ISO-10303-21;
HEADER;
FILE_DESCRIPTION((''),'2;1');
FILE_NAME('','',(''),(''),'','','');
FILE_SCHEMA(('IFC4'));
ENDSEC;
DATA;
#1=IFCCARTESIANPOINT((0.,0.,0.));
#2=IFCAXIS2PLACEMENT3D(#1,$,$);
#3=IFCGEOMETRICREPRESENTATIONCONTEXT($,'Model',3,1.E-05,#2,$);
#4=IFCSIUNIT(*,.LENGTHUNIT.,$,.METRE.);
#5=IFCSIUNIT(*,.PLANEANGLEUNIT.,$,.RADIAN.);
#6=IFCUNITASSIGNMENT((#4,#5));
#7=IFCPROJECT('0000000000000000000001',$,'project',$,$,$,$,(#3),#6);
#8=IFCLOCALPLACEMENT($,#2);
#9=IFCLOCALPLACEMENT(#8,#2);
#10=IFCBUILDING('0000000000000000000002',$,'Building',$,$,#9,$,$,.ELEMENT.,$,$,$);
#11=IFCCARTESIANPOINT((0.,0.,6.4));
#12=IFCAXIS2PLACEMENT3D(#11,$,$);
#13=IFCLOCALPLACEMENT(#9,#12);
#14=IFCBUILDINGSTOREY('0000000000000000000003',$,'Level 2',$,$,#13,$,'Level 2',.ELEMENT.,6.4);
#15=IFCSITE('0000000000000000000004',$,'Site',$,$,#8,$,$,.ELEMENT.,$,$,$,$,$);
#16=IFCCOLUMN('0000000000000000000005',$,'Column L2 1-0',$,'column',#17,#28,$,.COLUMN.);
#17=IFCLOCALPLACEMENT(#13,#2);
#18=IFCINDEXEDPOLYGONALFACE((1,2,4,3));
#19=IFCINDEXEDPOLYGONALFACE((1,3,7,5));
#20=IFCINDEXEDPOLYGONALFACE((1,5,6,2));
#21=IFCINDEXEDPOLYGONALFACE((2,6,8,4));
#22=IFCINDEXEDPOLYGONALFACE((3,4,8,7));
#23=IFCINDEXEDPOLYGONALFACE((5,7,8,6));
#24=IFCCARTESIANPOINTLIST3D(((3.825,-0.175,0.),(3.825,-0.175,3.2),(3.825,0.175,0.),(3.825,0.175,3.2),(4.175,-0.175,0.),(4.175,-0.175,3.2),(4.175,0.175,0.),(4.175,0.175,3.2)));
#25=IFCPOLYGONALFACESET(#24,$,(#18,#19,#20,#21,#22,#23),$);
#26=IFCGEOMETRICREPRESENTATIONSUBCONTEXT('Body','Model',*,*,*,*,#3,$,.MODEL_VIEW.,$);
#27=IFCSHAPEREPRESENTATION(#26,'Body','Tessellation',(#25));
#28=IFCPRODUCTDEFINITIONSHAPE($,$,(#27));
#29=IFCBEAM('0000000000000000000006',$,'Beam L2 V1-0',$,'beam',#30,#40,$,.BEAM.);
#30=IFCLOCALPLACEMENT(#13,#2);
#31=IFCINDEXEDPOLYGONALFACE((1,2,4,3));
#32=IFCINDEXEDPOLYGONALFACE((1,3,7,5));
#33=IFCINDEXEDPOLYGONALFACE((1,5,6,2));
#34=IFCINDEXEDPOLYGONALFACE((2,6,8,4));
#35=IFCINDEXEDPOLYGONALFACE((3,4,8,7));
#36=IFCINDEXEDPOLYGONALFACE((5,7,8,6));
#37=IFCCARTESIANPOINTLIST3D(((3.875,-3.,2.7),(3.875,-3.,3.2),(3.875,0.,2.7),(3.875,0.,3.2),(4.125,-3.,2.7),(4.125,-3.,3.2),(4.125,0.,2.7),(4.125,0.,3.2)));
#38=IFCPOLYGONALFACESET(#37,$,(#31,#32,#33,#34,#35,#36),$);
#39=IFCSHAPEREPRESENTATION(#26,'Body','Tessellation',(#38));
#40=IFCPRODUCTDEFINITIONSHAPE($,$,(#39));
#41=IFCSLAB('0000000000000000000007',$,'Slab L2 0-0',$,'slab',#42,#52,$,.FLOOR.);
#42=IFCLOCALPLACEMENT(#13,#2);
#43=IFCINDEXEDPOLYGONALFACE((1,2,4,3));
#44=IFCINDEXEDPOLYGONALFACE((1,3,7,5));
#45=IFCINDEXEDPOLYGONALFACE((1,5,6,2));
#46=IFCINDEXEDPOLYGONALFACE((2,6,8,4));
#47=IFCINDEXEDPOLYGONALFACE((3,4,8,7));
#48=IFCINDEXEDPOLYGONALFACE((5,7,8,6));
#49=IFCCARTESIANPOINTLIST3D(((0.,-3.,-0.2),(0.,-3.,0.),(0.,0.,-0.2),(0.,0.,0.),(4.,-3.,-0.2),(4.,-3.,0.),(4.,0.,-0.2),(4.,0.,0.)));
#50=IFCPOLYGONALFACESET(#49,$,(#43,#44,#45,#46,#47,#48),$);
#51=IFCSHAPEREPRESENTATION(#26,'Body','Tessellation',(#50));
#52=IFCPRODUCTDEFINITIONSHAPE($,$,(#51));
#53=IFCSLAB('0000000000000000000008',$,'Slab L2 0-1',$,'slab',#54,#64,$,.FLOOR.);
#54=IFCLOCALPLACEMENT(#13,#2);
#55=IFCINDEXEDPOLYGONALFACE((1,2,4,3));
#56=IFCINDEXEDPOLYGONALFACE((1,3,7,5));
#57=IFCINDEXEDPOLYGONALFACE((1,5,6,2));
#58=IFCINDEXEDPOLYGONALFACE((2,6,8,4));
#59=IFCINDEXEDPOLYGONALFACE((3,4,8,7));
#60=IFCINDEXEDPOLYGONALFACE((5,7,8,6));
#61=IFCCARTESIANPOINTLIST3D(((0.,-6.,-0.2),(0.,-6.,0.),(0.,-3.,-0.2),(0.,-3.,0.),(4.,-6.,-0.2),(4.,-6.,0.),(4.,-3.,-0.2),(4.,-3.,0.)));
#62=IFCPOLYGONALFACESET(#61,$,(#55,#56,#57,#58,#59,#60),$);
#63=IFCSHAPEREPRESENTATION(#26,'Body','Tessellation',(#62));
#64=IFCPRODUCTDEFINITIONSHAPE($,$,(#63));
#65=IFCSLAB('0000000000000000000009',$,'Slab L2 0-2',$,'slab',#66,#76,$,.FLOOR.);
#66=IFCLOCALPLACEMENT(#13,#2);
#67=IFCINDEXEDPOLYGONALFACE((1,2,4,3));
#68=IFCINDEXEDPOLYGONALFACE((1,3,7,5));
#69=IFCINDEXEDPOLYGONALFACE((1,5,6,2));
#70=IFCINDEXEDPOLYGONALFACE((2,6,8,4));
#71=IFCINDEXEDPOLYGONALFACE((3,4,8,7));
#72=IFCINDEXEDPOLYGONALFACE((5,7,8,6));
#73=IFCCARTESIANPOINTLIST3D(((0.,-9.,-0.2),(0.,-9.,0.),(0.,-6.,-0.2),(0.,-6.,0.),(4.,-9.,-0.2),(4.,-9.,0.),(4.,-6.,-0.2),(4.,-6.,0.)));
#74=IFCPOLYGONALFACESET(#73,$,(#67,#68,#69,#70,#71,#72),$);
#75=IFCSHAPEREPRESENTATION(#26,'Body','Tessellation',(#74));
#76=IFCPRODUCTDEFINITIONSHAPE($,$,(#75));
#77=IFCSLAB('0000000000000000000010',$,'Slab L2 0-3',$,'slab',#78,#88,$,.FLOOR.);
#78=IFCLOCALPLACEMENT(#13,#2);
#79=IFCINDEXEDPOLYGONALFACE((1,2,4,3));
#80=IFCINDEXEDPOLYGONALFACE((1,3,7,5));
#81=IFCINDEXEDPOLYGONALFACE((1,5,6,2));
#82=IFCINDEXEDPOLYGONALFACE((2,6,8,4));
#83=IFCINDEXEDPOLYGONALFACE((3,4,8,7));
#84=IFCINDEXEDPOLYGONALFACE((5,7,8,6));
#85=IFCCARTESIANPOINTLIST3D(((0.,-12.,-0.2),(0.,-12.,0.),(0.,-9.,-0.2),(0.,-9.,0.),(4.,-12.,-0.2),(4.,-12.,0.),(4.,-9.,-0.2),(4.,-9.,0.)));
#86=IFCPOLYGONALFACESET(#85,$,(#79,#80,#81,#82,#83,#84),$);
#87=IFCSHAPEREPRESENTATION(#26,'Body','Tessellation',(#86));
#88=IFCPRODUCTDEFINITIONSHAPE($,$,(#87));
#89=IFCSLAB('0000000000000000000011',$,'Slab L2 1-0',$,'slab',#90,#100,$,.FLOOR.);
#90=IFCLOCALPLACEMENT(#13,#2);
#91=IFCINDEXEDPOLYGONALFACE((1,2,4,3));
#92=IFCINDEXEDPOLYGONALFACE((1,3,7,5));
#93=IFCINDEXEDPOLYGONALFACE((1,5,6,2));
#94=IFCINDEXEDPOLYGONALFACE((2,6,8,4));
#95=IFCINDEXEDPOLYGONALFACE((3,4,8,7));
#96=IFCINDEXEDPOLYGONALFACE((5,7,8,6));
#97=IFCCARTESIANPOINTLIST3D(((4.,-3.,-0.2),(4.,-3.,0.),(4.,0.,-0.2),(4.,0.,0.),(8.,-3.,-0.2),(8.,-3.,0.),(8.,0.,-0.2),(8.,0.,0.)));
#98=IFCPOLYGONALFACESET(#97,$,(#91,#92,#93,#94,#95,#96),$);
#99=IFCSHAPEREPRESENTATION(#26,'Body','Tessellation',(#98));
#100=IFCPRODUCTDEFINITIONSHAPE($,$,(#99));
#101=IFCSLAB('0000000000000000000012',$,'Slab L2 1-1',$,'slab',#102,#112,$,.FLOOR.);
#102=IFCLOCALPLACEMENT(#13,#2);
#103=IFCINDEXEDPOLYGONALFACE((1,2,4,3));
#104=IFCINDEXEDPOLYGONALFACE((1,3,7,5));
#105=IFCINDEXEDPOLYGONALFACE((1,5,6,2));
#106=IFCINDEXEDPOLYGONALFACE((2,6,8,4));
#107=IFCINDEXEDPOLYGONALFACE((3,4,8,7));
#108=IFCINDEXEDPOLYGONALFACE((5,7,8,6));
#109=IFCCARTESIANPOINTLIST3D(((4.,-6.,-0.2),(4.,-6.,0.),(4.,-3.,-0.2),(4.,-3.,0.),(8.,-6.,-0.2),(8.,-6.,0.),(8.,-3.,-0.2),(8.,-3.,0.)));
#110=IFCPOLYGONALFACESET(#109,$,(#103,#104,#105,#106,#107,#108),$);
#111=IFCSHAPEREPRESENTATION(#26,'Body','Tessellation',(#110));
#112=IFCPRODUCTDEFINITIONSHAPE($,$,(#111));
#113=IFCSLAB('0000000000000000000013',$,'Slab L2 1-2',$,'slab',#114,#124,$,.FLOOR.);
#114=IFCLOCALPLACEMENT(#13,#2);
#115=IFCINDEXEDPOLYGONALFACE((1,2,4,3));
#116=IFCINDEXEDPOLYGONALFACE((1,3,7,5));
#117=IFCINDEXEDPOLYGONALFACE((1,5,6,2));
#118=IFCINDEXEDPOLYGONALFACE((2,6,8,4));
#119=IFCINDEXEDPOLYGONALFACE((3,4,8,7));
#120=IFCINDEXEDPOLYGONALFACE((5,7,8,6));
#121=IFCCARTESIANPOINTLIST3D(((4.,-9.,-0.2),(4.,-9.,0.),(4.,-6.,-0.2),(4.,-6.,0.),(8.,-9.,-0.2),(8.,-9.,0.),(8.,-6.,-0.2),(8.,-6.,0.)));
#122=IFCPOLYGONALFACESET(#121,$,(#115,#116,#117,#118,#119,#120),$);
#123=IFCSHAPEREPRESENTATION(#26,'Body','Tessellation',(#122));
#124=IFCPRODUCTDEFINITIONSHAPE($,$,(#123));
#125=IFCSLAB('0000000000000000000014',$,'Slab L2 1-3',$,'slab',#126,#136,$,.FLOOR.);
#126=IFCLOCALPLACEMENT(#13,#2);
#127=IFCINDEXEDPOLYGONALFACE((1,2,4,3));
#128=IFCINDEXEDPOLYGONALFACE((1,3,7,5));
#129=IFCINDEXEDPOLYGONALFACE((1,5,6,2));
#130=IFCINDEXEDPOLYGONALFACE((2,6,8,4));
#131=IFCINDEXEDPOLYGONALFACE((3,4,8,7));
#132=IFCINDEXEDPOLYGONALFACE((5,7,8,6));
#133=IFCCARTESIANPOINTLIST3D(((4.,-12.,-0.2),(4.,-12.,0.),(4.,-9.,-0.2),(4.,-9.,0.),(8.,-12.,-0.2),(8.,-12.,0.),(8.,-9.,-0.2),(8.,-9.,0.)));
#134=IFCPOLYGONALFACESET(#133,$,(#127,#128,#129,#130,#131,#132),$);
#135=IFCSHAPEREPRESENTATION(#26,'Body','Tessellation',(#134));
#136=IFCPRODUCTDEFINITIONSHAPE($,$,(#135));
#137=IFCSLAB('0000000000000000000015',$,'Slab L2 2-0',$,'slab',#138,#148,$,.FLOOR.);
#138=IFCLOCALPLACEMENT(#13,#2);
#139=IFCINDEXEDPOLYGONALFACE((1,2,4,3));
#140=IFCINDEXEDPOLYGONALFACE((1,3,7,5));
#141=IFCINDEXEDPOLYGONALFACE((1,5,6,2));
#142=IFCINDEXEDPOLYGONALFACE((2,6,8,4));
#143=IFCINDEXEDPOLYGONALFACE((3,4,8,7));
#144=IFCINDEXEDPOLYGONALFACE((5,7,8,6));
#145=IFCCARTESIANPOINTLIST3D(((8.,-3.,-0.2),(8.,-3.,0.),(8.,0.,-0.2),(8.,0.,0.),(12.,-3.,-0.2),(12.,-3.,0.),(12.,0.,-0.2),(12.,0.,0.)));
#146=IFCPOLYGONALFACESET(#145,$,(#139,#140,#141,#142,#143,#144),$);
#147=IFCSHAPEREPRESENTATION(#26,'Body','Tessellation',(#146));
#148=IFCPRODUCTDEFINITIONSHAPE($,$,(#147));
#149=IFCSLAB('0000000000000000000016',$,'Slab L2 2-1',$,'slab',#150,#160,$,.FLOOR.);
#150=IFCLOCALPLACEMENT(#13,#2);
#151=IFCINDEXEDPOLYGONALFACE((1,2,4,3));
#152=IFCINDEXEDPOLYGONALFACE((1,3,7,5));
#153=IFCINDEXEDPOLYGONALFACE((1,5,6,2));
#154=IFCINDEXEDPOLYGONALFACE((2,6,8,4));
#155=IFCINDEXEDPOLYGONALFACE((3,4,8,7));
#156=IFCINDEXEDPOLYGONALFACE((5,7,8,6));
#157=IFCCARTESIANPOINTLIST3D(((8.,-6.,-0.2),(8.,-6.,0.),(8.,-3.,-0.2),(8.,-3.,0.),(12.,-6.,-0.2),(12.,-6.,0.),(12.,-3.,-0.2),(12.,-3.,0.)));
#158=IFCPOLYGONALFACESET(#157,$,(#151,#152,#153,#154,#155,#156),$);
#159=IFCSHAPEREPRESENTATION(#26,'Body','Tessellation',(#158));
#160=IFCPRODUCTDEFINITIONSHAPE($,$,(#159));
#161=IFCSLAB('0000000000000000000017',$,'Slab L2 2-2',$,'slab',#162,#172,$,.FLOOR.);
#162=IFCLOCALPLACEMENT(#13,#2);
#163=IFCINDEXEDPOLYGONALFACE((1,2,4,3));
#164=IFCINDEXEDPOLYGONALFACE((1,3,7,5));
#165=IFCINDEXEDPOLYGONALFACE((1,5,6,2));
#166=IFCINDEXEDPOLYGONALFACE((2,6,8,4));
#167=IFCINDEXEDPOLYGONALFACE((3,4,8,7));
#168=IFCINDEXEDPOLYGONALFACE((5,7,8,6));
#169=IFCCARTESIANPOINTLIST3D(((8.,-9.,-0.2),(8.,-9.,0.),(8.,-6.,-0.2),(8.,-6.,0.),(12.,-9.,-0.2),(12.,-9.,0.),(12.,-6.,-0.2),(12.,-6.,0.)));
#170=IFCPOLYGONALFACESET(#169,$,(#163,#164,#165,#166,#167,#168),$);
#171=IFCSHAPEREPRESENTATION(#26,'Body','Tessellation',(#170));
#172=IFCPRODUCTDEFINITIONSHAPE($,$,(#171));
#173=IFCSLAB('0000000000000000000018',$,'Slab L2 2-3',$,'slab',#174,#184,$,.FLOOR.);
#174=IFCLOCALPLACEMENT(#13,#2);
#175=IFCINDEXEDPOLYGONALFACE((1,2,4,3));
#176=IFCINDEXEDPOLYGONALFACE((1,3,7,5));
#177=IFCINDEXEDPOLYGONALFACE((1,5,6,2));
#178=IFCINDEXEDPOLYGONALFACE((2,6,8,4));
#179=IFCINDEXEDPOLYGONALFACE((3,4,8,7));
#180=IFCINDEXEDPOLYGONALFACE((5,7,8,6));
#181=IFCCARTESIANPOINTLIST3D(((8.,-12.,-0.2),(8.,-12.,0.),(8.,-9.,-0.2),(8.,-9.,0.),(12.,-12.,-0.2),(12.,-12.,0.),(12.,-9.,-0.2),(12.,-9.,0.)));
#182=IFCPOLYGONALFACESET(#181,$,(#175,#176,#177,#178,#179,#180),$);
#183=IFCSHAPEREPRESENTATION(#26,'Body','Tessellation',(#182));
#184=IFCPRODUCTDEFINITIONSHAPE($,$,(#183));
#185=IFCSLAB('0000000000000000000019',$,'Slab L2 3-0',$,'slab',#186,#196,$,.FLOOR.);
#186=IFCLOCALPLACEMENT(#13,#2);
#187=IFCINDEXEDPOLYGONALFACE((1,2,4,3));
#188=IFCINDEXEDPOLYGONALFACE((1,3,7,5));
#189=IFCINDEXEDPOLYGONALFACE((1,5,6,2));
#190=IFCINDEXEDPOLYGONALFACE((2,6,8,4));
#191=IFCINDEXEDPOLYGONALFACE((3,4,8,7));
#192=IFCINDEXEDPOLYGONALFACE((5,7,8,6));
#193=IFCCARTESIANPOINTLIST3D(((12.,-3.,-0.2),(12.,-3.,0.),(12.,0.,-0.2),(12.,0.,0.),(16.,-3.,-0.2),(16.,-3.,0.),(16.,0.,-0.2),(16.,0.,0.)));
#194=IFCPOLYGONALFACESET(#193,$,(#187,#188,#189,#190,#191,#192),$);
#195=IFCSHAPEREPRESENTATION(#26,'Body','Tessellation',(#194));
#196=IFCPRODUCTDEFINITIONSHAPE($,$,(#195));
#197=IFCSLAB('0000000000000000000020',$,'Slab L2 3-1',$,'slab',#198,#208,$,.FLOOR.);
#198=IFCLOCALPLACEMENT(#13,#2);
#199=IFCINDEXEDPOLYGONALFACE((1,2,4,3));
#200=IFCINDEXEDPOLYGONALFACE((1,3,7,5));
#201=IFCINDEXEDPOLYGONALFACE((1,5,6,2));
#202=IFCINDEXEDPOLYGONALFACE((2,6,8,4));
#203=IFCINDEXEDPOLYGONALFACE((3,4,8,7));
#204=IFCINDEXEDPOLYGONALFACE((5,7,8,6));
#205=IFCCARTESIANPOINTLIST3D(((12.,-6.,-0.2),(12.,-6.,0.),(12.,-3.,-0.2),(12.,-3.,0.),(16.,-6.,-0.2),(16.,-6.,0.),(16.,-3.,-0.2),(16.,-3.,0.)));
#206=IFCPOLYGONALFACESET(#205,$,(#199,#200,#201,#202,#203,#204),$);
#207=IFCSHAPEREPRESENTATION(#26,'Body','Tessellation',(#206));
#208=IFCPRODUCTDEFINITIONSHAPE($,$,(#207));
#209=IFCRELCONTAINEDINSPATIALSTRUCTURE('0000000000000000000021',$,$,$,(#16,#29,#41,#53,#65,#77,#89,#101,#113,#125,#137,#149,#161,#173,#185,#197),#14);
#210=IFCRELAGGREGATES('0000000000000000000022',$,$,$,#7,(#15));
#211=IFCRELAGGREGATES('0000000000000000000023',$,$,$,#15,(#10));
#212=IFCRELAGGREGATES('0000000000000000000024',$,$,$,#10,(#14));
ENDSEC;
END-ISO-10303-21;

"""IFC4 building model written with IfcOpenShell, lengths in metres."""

from ifc_helpers import new_model, si_unit, frame, origin, origin_2d, place, context, subcontext, project, spatial, polyline, rectangle, outline, extrude, element, save


model = new_model("IFC4")

# Units and contexts
model_context = context("Model", 3, precision=1e-05, world=origin())
body_context = subcontext(model_context, "Body", "Model", "MODEL_VIEW")
ifc_project = project(units=[si_unit("LENGTHUNIT", "METRE"), si_unit("PLANEANGLEUNIT", "RADIAN")], contexts=[model_context])

# Site, building, storey
site_placement = place(None, origin())
site = spatial("IfcSite", under=ifc_project, at=site_placement, Name="Site", CompositionType="ELEMENT")
building_placement = place(site_placement, origin())
building = spatial("IfcBuilding", under=site, at=building_placement, Name="Building", CompositionType="ELEMENT")
storey_placement = place(building_placement, frame((0.0, 0.0, 6.4)))
storey = spatial("IfcBuildingStorey", under=building, at=storey_placement, Name="Level 2", LongName="Level 2", CompositionType="ELEMENT", Elevation=6.4)

# Column
column_placement = place(storey_placement, frame((4.0, 0.0, 0.0)))
element("IfcColumn", 1, at=column_placement, inside=storey, Name="Column L2 1-0", ObjectType="column", PredefinedType="COLUMN", context=body_context, shape_type="SweptSolid", body=[
    extrude(rectangle(XDim=0.35, YDim=0.35, at=origin_2d()), origin(), (0.0, 0.0, 1.0), 3.2),
])

# Beam
beam_placement = place(storey_placement, frame((4.0, 0.0, 2.95), z_axis=(0.0, -1.0, 0.0), x_axis=(0.0, 0.0, 1.0)))
element("IfcBeam", 2, at=beam_placement, inside=storey, Name="Beam L2 V1-0", ObjectType="beam", PredefinedType="BEAM", context=body_context, shape_type="SweptSolid", body=[
    extrude(rectangle(XDim=0.5, YDim=0.25, at=origin_2d()), origin(), (0.0, 0.0, 1.0), 3.0),
])

# Slabs
slab_1_placement = place(storey_placement, frame((0.0, 0.0, -0.2)))
element("IfcSlab", 3, at=slab_1_placement, inside=storey, Name="Slab L2 0-0", ObjectType="slab", PredefinedType="FLOOR", context=body_context, shape_type="SweptSolid", body=[
    extrude(outline(polyline([(0.0, -3.0), (4.0, -3.0), (4.0, 0.0), (0.0, 0.0), (0.0, -3.0)])), origin(), (0.0, 0.0, 1.0), 0.2),
])
slab_2_placement = place(storey_placement, frame((0.0, 0.0, -0.2)))
element("IfcSlab", 4, at=slab_2_placement, inside=storey, Name="Slab L2 0-1", ObjectType="slab", PredefinedType="FLOOR", context=body_context, shape_type="SweptSolid", body=[
    extrude(outline(polyline([(0.0, -6.0), (4.0, -6.0), (4.0, -3.0), (0.0, -3.0), (0.0, -6.0)])), origin(), (0.0, 0.0, 1.0), 0.2),
])
slab_3_placement = place(storey_placement, frame((0.0, 0.0, -0.2)))
element("IfcSlab", 5, at=slab_3_placement, inside=storey, Name="Slab L2 0-2", ObjectType="slab", PredefinedType="FLOOR", context=body_context, shape_type="SweptSolid", body=[
    extrude(outline(polyline([(0.0, -9.0), (4.0, -9.0), (4.0, -6.0), (0.0, -6.0), (0.0, -9.0)])), origin(), (0.0, 0.0, 1.0), 0.2),
])
slab_4_placement = place(storey_placement, frame((0.0, 0.0, -0.2)))
element("IfcSlab", 6, at=slab_4_placement, inside=storey, Name="Slab L2 0-3", ObjectType="slab", PredefinedType="FLOOR", context=body_context, shape_type="SweptSolid", body=[
    extrude(outline(polyline([(0.0, -12.0), (4.0, -12.0), (4.0, -9.0), (0.0, -9.0), (0.0, -12.0)])), origin(), (0.0, 0.0, 1.0), 0.2),
])
slab_5_placement = place(storey_placement, frame((0.0, 0.0, -0.2)))
element("IfcSlab", 7, at=slab_5_placement, inside=storey, Name="Slab L2 1-0", ObjectType="slab", PredefinedType="FLOOR", context=body_context, shape_type="SweptSolid", body=[
    extrude(outline(polyline([(4.0, -3.0), (8.0, -3.0), (8.0, 0.0), (4.0, 0.0), (4.0, -3.0)])), origin(), (0.0, 0.0, 1.0), 0.2),
])
slab_6_placement = place(storey_placement, frame((0.0, 0.0, -0.2)))
element("IfcSlab", 8, at=slab_6_placement, inside=storey, Name="Slab L2 1-1", ObjectType="slab", PredefinedType="FLOOR", context=body_context, shape_type="SweptSolid", body=[
    extrude(outline(polyline([(4.0, -6.0), (8.0, -6.0), (8.0, -3.0), (4.0, -3.0), (4.0, -6.0)])), origin(), (0.0, 0.0, 1.0), 0.2),
])
slab_7_placement = place(storey_placement, frame((0.0, 0.0, -0.2)))
element("IfcSlab", 9, at=slab_7_placement, inside=storey, Name="Slab L2 1-2", ObjectType="slab", PredefinedType="FLOOR", context=body_context, shape_type="SweptSolid", body=[
    extrude(outline(polyline([(4.0, -9.0), (8.0, -9.0), (8.0, -6.0), (4.0, -6.0), (4.0, -9.0)])), origin(), (0.0, 0.0, 1.0), 0.2),
])
slab_8_placement = place(storey_placement, frame((0.0, 0.0, -0.2)))
element("IfcSlab", 10, at=slab_8_placement, inside=storey, Name="Slab L2 1-3", ObjectType="slab", PredefinedType="FLOOR", context=body_context, shape_type="SweptSolid", body=[
    extrude(outline(polyline([(4.0, -12.0), (8.0, -12.0), (8.0, -9.0), (4.0, -9.0), (4.0, -12.0)])), origin(), (0.0, 0.0, 1.0), 0.2),
])
slab_9_placement = place(storey_placement, frame((0.0, 0.0, -0.2)))
element("IfcSlab", 11, at=slab_9_placement, inside=storey, Name="Slab L2 2-0", ObjectType="slab", PredefinedType="FLOOR", context=body_context, shape_type="SweptSolid", body=[
    extrude(outline(polyline([(8.0, -3.0), (12.0, -3.0), (12.0, 0.0), (8.0, 0.0), (8.0, -3.0)])), origin(), (0.0, 0.0, 1.0), 0.2),
])
slab_10_placement = place(storey_placement, frame((0.0, 0.0, -0.2)))
element("IfcSlab", 12, at=slab_10_placement, inside=storey, Name="Slab L2 2-1", ObjectType="slab", PredefinedType="FLOOR", context=body_context, shape_type="SweptSolid", body=[
    extrude(outline(polyline([(8.0, -6.0), (12.0, -6.0), (12.0, -3.0), (8.0, -3.0), (8.0, -6.0)])), origin(), (0.0, 0.0, 1.0), 0.2),
])
slab_11_placement = place(storey_placement, frame((0.0, 0.0, -0.2)))
element("IfcSlab", 13, at=slab_11_placement, inside=storey, Name="Slab L2 2-2", ObjectType="slab", PredefinedType="FLOOR", context=body_context, shape_type="SweptSolid", body=[
    extrude(outline(polyline([(8.0, -9.0), (12.0, -9.0), (12.0, -6.0), (8.0, -6.0), (8.0, -9.0)])), origin(), (0.0, 0.0, 1.0), 0.2),
])
slab_12_placement = place(storey_placement, frame((0.0, 0.0, -0.2)))
element("IfcSlab", 14, at=slab_12_placement, inside=storey, Name="Slab L2 2-3", ObjectType="slab", PredefinedType="FLOOR", context=body_context, shape_type="SweptSolid", body=[
    extrude(outline(polyline([(8.0, -12.0), (12.0, -12.0), (12.0, -9.0), (8.0, -9.0), (8.0, -12.0)])), origin(), (0.0, 0.0, 1.0), 0.2),
])
slab_13_placement = place(storey_placement, frame((0.0, 0.0, -0.2)))
element("IfcSlab", 15, at=slab_13_placement, inside=storey, Name="Slab L2 3-0", ObjectType="slab", PredefinedType="FLOOR", context=body_context, shape_type="SweptSolid", body=[
    extrude(outline(polyline([(12.0, -3.0), (16.0, -3.0), (16.0, 0.0), (12.0, 0.0), (12.0, -3.0)])), origin(), (0.0, 0.0, 1.0), 0.2),
])
slab_14_placement = place(storey_placement, frame((0.0, 0.0, -0.2)))
element("IfcSlab", 16, at=slab_14_placement, inside=storey, Name="Slab L2 3-1", ObjectType="slab", PredefinedType="FLOOR", context=body_context, shape_type="SweptSolid", body=[
    extrude(outline(polyline([(12.0, -6.0), (16.0, -6.0), (16.0, -3.0), (12.0, -3.0), (12.0, -6.0)])), origin(), (0.0, 0.0, 1.0), 0.2),
])

save(model, "model.ifc")
